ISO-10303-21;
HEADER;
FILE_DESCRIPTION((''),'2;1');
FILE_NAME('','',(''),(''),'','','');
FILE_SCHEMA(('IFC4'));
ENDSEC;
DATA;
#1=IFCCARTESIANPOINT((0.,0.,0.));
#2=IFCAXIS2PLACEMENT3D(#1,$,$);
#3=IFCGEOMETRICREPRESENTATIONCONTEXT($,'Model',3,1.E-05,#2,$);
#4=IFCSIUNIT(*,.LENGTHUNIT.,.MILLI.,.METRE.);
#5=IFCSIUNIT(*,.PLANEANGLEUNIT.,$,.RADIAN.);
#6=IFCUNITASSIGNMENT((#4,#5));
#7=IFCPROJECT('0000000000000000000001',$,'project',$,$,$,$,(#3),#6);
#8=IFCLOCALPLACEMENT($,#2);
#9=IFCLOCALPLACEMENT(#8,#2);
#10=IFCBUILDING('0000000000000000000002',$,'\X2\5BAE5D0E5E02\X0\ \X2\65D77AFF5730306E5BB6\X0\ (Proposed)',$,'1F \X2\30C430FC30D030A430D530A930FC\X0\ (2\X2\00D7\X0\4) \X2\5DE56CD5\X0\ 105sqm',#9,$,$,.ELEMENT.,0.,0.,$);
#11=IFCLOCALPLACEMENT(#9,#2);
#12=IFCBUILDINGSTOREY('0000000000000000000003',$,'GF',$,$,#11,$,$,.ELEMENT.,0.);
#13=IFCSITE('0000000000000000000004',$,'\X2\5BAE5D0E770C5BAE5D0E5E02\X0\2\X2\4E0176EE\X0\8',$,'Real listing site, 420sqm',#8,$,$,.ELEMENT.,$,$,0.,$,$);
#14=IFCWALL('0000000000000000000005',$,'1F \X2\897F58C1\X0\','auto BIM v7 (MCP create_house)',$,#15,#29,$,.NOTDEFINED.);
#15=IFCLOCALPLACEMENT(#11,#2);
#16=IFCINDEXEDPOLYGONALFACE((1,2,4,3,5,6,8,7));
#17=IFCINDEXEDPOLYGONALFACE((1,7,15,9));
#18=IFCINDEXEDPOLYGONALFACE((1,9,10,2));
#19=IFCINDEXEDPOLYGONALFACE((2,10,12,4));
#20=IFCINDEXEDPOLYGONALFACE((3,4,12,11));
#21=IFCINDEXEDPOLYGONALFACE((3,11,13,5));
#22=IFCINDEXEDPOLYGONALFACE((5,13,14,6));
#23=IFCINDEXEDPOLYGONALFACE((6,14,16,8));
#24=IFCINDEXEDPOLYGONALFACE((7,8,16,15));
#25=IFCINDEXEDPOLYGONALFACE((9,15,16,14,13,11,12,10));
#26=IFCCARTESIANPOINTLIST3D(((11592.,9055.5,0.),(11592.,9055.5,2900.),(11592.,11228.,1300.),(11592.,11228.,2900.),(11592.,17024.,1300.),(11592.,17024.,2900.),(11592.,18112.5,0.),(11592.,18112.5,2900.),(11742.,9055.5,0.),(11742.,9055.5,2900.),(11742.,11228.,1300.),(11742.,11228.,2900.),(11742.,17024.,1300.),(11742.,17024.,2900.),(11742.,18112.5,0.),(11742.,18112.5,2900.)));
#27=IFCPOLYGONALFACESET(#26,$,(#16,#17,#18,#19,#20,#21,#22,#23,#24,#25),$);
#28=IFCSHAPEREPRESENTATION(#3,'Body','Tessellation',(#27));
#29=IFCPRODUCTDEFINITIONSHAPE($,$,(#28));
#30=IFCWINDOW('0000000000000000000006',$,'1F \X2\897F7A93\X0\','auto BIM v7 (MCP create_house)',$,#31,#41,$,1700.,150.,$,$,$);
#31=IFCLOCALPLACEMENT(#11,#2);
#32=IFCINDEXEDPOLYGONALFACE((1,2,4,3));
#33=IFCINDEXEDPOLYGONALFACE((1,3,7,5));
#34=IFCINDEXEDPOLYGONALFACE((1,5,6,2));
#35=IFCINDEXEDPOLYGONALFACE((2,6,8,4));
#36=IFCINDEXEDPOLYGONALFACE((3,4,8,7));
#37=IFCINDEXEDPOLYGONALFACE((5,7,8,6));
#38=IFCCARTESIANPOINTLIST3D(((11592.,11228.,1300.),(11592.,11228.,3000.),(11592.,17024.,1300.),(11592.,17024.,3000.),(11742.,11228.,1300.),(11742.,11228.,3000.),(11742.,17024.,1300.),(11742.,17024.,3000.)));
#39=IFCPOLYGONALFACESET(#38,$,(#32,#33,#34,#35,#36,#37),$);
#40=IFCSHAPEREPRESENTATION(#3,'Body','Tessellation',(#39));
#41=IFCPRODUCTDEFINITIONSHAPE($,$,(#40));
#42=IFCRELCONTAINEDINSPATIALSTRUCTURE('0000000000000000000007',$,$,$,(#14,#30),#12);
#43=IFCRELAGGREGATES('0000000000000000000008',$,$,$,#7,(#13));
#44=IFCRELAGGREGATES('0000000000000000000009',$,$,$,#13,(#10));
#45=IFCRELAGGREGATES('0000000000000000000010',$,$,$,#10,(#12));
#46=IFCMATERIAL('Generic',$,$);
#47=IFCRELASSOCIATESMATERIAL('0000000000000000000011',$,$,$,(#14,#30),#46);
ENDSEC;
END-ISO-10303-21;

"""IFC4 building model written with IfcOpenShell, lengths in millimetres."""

from ifc_helpers import new_model, si_unit, frame, frame_2d, origin, place, context, project, spatial, rectangle, extrude, material, element, fill, save


model = new_model("IFC4")

# Units and contexts
model_context = context("Model", 3, precision=1e-05, world=origin())
ifc_project = project(units=[si_unit("LENGTHUNIT", "METRE", prefix="MILLI"), si_unit("PLANEANGLEUNIT", "RADIAN")], contexts=[model_context])

# Site, building, storey
site_placement = place(None, origin())
site = spatial("IfcSite", under=ifc_project, at=site_placement, Name="宮崎県宮崎市2丁目8", ObjectType="Real listing site, 420sqm", CompositionType="ELEMENT", RefElevation=0.0)
building_placement = place(site_placement, origin())
building = spatial("IfcBuilding", under=site, at=building_placement, Name="宮崎市 旗竿地の家 (Proposed)", ObjectType="1F ツーバイフォー (2×4) 工法 105sqm", CompositionType="ELEMENT", ElevationOfRefHeight=0.0, ElevationOfTerrain=0.0)
storey_placement = place(building_placement, origin())
storey = spatial("IfcBuildingStorey", under=building, at=storey_placement, Name="GF", CompositionType="ELEMENT", Elevation=0.0)

# Shared definitions
ifc_material = material(Name="Generic")

# Wall, opening, window
wall_1_placement = place(storey_placement, frame((5796.0, 4528.0, 0.0)))
wall_1 = element("IfcWall", 1, at=wall_1_placement, inside=storey, material=ifc_material, Name="1F 西壁", Description="auto BIM v7 (MCP create_house)", PredefinedType="NOTDEFINED", context=model_context, shape_type="SweptSolid", body=[
    extrude(rectangle(XDim=150.0, YDim=9057.0, at=frame_2d((75.0, 4528.0))), frame((5796.0, 4528.0, 0.0)), (0.0, 0.0, 1.0), 2900.0),
])
opening_1_placement = place(storey_placement, frame((5796.0, 5614.0, 650.0)))
opening_1 = element("IfcOpeningElement", 2, at=opening_1_placement, cuts=wall_1, PredefinedType="NOTDEFINED", context=model_context, shape_type="SweptSolid", body=[
    extrude(rectangle(XDim=150.0, YDim=5796.0, at=frame_2d((75.0, 2898.0))), frame((5796.0, 5614.0, 650.0)), (0.0, 0.0, 1.0), 1700.0),
])
window_1_placement = place(storey_placement, frame((5796.0, 5614.0, 650.0)))
window_1 = element("IfcWindow", 3, at=window_1_placement, inside=storey, material=ifc_material, Name="1F 西窓", Description="auto BIM v7 (MCP create_house)", OverallHeight=1700.0, OverallWidth=150.0, context=model_context, shape_type="SweptSolid", body=[
    extrude(rectangle(XDim=150.0, YDim=5796.0, at=frame_2d((75.0, 2898.0))), frame((5796.0, 5614.0, 650.0)), (0.0, 0.0, 1.0), 1700.0),
])
fill(opening_1, window_1)

save(model, "model.ifc")
